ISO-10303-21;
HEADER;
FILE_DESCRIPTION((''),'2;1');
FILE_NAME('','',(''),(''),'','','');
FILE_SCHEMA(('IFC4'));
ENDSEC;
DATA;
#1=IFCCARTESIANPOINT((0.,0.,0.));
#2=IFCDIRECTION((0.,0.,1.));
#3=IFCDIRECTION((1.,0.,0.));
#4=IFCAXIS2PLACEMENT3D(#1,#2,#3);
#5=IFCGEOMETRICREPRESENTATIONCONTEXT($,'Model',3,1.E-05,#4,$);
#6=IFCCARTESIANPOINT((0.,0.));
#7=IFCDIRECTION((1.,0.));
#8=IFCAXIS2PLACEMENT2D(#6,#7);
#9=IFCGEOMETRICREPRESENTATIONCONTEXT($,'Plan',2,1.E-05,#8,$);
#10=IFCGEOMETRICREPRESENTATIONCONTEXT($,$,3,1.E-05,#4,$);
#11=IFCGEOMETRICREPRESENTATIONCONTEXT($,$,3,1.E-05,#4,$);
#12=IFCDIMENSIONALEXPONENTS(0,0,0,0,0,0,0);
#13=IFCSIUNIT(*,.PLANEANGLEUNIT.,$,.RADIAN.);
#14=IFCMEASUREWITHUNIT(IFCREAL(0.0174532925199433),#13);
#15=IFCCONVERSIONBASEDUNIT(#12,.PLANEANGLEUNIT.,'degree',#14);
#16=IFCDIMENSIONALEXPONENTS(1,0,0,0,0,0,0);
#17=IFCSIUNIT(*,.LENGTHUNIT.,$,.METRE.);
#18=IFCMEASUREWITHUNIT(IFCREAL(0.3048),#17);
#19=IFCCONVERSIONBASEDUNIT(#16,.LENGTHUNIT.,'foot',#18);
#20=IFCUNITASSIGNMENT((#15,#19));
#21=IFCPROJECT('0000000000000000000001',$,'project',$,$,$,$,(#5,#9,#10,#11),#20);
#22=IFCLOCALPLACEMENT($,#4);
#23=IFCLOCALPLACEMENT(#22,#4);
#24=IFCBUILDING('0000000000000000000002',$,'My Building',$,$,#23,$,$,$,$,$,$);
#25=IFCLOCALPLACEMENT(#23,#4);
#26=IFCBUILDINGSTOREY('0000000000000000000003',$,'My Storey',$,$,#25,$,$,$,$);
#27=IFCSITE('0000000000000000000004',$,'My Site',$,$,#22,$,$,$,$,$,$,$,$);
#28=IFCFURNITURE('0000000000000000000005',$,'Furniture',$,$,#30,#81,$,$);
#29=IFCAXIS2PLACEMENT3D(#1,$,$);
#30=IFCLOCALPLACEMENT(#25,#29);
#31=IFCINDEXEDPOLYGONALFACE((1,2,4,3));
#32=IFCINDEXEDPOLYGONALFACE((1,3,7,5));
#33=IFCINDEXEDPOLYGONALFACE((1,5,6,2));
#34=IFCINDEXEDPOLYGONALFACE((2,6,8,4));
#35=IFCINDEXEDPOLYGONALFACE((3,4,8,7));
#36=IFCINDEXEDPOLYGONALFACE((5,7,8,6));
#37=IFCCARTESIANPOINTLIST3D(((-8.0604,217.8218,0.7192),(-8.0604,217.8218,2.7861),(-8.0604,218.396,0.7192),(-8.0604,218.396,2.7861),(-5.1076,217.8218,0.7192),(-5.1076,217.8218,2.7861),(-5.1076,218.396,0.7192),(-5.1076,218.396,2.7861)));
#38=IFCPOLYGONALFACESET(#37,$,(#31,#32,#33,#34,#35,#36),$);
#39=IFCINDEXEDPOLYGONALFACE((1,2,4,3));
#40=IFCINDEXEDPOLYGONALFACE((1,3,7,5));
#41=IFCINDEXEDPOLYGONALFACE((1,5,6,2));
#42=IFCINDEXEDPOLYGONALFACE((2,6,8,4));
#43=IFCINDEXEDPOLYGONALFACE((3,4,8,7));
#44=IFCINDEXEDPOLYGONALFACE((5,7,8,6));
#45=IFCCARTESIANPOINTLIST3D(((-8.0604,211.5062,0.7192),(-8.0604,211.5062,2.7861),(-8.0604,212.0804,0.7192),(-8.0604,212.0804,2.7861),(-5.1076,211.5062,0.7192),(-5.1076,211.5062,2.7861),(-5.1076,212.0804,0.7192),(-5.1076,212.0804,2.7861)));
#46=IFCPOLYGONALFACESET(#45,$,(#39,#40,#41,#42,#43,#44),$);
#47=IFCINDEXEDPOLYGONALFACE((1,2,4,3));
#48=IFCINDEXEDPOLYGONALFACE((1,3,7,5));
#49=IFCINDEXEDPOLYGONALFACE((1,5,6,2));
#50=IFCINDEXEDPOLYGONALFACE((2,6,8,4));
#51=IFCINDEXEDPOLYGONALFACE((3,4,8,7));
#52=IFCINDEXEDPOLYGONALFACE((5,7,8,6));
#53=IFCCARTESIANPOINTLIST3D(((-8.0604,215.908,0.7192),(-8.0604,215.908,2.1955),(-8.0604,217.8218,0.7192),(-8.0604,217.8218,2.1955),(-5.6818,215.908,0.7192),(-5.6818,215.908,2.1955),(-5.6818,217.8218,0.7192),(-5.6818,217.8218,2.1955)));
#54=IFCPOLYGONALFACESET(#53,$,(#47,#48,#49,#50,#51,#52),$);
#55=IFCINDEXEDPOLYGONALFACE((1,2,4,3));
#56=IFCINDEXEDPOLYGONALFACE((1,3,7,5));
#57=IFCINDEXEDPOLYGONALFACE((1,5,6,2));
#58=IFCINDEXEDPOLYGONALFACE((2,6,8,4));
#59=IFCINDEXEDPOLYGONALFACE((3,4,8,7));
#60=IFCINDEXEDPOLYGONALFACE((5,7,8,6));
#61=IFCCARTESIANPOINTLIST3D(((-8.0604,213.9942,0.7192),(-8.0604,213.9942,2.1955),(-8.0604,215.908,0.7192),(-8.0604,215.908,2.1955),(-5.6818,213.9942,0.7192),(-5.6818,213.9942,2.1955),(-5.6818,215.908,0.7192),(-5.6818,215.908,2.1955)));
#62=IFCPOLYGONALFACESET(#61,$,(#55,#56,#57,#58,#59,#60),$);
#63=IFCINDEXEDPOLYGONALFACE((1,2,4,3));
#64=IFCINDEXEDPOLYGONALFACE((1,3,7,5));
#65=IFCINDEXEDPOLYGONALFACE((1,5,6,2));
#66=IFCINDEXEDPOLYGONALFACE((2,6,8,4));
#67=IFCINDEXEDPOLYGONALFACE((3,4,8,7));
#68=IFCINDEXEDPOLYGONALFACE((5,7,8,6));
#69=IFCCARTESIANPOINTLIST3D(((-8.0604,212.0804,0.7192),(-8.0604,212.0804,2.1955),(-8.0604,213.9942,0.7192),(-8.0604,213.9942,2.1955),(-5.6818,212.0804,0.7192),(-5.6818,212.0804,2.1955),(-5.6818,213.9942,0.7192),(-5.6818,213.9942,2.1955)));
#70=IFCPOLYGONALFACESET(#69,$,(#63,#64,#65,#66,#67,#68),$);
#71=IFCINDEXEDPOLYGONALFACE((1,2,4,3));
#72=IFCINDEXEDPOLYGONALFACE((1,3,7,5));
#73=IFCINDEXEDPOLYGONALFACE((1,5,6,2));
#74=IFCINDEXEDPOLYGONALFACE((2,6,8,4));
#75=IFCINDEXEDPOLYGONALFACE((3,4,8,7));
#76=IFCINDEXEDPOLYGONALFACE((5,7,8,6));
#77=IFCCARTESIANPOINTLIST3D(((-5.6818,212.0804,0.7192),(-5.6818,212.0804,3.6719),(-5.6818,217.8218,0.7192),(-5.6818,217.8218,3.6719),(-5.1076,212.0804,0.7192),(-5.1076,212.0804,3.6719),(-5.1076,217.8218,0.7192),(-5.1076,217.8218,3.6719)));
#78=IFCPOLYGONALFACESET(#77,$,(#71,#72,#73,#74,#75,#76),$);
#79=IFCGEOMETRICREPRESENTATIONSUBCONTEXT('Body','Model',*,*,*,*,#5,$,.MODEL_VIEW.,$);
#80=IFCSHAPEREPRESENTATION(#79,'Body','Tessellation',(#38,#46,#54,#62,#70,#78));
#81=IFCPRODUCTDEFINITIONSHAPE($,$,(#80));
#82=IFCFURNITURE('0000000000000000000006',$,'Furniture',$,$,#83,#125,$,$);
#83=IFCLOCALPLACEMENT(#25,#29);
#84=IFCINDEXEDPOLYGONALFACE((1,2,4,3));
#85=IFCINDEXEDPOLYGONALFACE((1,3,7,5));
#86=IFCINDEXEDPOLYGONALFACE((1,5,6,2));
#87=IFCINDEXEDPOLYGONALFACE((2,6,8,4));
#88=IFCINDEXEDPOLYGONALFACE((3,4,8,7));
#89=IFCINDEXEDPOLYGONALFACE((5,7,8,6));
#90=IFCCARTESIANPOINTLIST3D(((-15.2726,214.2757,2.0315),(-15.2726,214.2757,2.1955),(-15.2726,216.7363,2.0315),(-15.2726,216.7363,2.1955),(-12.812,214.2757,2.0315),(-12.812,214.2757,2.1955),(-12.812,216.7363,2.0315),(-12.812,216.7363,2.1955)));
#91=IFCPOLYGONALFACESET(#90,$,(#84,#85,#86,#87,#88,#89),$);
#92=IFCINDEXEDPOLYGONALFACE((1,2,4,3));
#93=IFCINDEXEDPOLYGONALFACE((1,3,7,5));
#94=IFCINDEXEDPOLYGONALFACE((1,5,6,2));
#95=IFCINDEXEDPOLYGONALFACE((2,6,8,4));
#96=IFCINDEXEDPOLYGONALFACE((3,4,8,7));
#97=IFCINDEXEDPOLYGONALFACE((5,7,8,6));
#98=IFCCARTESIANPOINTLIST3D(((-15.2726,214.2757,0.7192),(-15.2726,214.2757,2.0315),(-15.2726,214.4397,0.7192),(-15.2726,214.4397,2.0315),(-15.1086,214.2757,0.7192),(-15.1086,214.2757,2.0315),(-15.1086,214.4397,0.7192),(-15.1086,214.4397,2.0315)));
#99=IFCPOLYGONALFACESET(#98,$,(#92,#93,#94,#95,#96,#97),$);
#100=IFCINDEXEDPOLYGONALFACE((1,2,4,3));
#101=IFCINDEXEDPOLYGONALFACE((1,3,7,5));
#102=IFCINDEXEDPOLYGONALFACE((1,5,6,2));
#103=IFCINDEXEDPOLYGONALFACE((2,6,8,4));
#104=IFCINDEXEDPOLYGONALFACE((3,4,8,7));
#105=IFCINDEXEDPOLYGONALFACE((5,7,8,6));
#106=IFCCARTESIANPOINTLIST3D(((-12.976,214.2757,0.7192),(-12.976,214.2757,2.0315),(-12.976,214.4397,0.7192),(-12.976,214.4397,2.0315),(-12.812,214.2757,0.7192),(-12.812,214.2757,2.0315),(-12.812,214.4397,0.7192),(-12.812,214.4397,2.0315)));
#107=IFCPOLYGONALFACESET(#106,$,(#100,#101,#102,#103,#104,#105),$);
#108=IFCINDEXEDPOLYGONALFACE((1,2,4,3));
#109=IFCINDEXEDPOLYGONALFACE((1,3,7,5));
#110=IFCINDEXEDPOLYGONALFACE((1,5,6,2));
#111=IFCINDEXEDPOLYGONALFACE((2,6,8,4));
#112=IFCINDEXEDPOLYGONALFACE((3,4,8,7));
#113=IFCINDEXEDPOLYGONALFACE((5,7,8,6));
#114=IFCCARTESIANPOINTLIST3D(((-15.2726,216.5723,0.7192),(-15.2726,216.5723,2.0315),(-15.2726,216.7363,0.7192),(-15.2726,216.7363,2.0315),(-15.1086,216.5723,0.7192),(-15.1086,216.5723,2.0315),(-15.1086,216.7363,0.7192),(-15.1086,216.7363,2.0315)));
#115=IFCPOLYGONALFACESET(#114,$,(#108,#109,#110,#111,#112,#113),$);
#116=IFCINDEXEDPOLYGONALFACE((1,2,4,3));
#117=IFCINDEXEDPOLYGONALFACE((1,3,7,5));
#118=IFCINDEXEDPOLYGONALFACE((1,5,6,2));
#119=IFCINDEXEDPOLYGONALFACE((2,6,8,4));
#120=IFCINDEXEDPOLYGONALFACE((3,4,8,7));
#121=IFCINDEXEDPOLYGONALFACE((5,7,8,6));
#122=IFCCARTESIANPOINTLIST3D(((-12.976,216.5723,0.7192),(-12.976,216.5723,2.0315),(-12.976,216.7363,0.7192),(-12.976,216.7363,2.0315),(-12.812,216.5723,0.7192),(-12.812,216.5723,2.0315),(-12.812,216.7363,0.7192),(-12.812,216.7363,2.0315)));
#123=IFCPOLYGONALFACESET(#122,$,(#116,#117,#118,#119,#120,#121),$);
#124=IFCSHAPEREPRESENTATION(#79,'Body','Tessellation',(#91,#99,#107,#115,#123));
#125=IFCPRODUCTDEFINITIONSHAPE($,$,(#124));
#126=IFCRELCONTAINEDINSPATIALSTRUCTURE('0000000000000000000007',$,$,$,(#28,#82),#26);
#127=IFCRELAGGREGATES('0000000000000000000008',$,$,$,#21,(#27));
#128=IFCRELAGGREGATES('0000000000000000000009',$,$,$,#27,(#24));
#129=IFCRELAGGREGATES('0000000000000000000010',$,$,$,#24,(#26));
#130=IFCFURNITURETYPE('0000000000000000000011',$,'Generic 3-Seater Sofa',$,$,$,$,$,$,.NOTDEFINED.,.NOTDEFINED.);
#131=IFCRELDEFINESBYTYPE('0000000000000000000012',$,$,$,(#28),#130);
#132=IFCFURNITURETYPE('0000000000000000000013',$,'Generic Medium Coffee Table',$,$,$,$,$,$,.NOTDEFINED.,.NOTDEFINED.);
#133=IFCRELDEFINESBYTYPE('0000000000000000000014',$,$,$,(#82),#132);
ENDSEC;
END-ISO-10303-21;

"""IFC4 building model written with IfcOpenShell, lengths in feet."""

from ifc_helpers import new_model, entity, si_unit, converted_unit, frame, origin_with_axes, origin_2d_with_axis, place, context, subcontext, project, spatial, line, indexed_curve, outline, extrude, shape, source, transform, mapped, type_object, type_shapes, element, save


model = new_model("IFC4")

# Units and contexts
model_context = context("Model", 3, precision=1e-05, world=origin_with_axes())
plan_context = context("Plan", 2, precision=1e-05, world=origin_2d_with_axis())
context_of_model_1 = context(None, 3, precision=1e-05, world=origin_with_axes())
context_of_model_2 = context(None, 3, precision=1e-05, world=origin_with_axes())
body_context_1 = subcontext(model_context, "Body", "Model", "MODEL_VIEW")
body_context_2 = subcontext(plan_context, "Body", "Plan", "PLAN_VIEW")
ifc_project = project(units=[converted_unit("PLANEANGLEUNIT", "degree", entity("IfcReal", 0.0174532925199433), si_unit("PLANEANGLEUNIT", "RADIAN"), dimensions=[0, 0, 0, 0, 0, 0, 0]), converted_unit("LENGTHUNIT", "foot", entity("IfcReal", 0.3048), si_unit("LENGTHUNIT", "METRE"), dimensions=[1, 0, 0, 0, 0, 0, 0])], contexts=[model_context, plan_context, context_of_model_1, context_of_model_2])

# Site, building, storey
site_placement = place(None, origin_with_axes())
site = spatial("IfcSite", under=ifc_project, at=site_placement, Name="My Site")
building_placement = place(site_placement, origin_with_axes())
building = spatial("IfcBuilding", under=site, at=building_placement, Name="My Building")
storey_placement = place(building_placement, origin_with_axes())
storey = spatial("IfcBuildingStorey", under=building, at=storey_placement, Name="My Storey")

# Furniture
furniture_type_1 = type_object("IfcFurnitureType", Name="Generic 3-Seater Sofa", AssemblyPlace="NOTDEFINED", PredefinedType="NOTDEFINED")
shared_shape_1 = source(origin_with_axes(), body_context_1, "Body", "SweptSolid", [
    extrude(outline(indexed_curve([(0.0, 0.0), (0.5741, 0.0), (0.5741, 2.9528), (0.0, 2.9528)], segments=[line(1, 2), line(2, 3), line(3, 4), line(4, 1)])), frame((-3.4449, -2.9528, 0.0), z_axis=(0.0, 0.0, 1.0), x_axis=(1.0, 0.0, 0.0)), (0.0, 0.0, 1.0), 2.0669),
    extrude(outline(indexed_curve([(0.0, 0.0), (0.5741, 0.0), (0.5741, 2.9528), (0.0, 2.9528)], segments=[line(1, 2), line(2, 3), line(3, 4), line(4, 1)])), frame((2.8707, -2.9528, 0.0), z_axis=(0.0, 0.0, 1.0), x_axis=(1.0, 0.0, 0.0)), (0.0, 0.0, 1.0), 2.0669),
    extrude(outline(indexed_curve([(0.5741, 0.0), (2.488, 0.0), (2.488, 2.3786), (0.5741, 2.3786)], segments=[line(1, 2), line(2, 3), line(3, 4), line(4, 1)])), frame((-3.4449, -2.9528, 0.0), z_axis=(0.0, 0.0, 1.0), x_axis=(1.0, 0.0, 0.0)), (0.0, 0.0, 1.0), 1.4764),
    extrude(outline(indexed_curve([(2.488, 0.0), (4.4018, 0.0), (4.4018, 2.3786), (2.488, 2.3786)], segments=[line(1, 2), line(2, 3), line(3, 4), line(4, 1)])), frame((-3.4449, -2.9528, 0.0), z_axis=(0.0, 0.0, 1.0), x_axis=(1.0, 0.0, 0.0)), (0.0, 0.0, 1.0), 1.4764),
    extrude(outline(indexed_curve([(4.4018, 0.0), (6.3156, 0.0), (6.3156, 2.3786), (4.4018, 2.3786)], segments=[line(1, 2), line(2, 3), line(3, 4), line(4, 1)])), frame((-3.4449, -2.9528, 0.0), z_axis=(0.0, 0.0, 1.0), x_axis=(1.0, 0.0, 0.0)), (0.0, 0.0, 1.0), 1.4764),
    extrude(outline(indexed_curve([(0.5741, 2.3786), (6.3156, 2.3786), (6.3156, 2.9528), (0.5741, 2.9528)], segments=[line(1, 2), line(2, 3), line(3, 4), line(4, 1)])), frame((-3.4449, -2.9528, 0.0), z_axis=(0.0, 0.0, 1.0), x_axis=(1.0, 0.0, 0.0)), (0.0, 0.0, 1.0), 2.9528),
])
shared_shape_2 = source(origin_with_axes(), body_context_2, "Body", "Annotation2D", [
    entity("IfcAnnotationFillArea", entity("IfcIndexedPolyCurve", entity("IfcCartesianPointList2D", [[-3.4449, -2.9528], [-2.8707, -2.9528], [-2.8707, 0.0], [-3.4449, 0.0], [2.8707, -2.9528], [3.4449, -2.9528], [3.4449, 0.0], [2.8707, 0.0], [-2.8707, -2.9528], [-0.9569, -2.9528], [-0.9569, -2.9528], [-0.9569, -0.5741], [-2.8707, -0.5741], [-0.9569, -2.9528], [0.9569, -2.9528], [0.9569, -2.9528], [0.9569, -0.5741], [-0.9569, -0.5741], [-0.9569, -0.5741], [0.9569, -2.9528], [2.8707, -2.9528], [2.8707, -0.5741], [0.9569, -0.5741], [-2.8707, -0.5741], [2.8707, -0.5741], [2.8707, 0.0], [-2.8707, 0.0], [0.9569, -0.5741]]), [entity("IfcLineIndex", [5, 8]), entity("IfcLineIndex", [8, 7]), entity("IfcLineIndex", [7, 6]), entity("IfcLineIndex", [6, 5])])),
    entity("IfcAnnotationFillArea", entity("IfcIndexedPolyCurve", entity("IfcCartesianPointList2D", [[-3.4449, -2.9528], [-2.8707, -2.9528], [-2.8707, 0.0], [-3.4449, 0.0], [2.8707, -2.9528], [3.4449, -2.9528], [3.4449, 0.0], [2.8707, 0.0], [-2.8707, -2.9528], [-0.9569, -2.9528], [-0.9569, -2.9528], [-0.9569, -0.5741], [-2.8707, -0.5741], [-0.9569, -2.9528], [0.9569, -2.9528], [0.9569, -2.9528], [0.9569, -0.5741], [-0.9569, -0.5741], [-0.9569, -0.5741], [0.9569, -2.9528], [2.8707, -2.9528], [2.8707, -0.5741], [0.9569, -0.5741], [-2.8707, -0.5741], [2.8707, -0.5741], [2.8707, 0.0], [-2.8707, 0.0], [0.9569, -0.5741]]), [entity("IfcLineIndex", [20, 23]), entity("IfcLineIndex", [23, 22]), entity("IfcLineIndex", [22, 21]), entity("IfcLineIndex", [21, 20])])),
    entity("IfcAnnotationFillArea", entity("IfcIndexedPolyCurve", entity("IfcCartesianPointList2D", [[-3.4449, -2.9528], [-2.8707, -2.9528], [-2.8707, 0.0], [-3.4449, 0.0], [2.8707, -2.9528], [3.4449, -2.9528], [3.4449, 0.0], [2.8707, 0.0], [-2.8707, -2.9528], [-0.9569, -2.9528], [-0.9569, -2.9528], [-0.9569, -0.5741], [-2.8707, -0.5741], [-0.9569, -2.9528], [0.9569, -2.9528], [0.9569, -2.9528], [0.9569, -0.5741], [-0.9569, -0.5741], [-0.9569, -0.5741], [0.9569, -2.9528], [2.8707, -2.9528], [2.8707, -0.5741], [0.9569, -0.5741], [-2.8707, -0.5741], [2.8707, -0.5741], [2.8707, 0.0], [-2.8707, 0.0], [0.9569, -0.5741]]), [entity("IfcLineIndex", [1, 4]), entity("IfcLineIndex", [4, 3]), entity("IfcLineIndex", [3, 2]), entity("IfcLineIndex", [2, 1])])),
    entity("IfcAnnotationFillArea", entity("IfcIndexedPolyCurve", entity("IfcCartesianPointList2D", [[-3.4449, -2.9528], [-2.8707, -2.9528], [-2.8707, 0.0], [-3.4449, 0.0], [2.8707, -2.9528], [3.4449, -2.9528], [3.4449, 0.0], [2.8707, 0.0], [-2.8707, -2.9528], [-0.9569, -2.9528], [-0.9569, -2.9528], [-0.9569, -0.5741], [-2.8707, -0.5741], [-0.9569, -2.9528], [0.9569, -2.9528], [0.9569, -2.9528], [0.9569, -0.5741], [-0.9569, -0.5741], [-0.9569, -0.5741], [0.9569, -2.9528], [2.8707, -2.9528], [2.8707, -0.5741], [0.9569, -0.5741], [-2.8707, -0.5741], [2.8707, -0.5741], [2.8707, 0.0], [-2.8707, 0.0], [0.9569, -0.5741]]), [entity("IfcLineIndex", [9, 13]), entity("IfcLineIndex", [13, 12]), entity("IfcLineIndex", [12, 11]), entity("IfcLineIndex", [11, 10]), entity("IfcLineIndex", [10, 9])])),
    entity("IfcAnnotationFillArea", entity("IfcIndexedPolyCurve", entity("IfcCartesianPointList2D", [[-3.4449, -2.9528], [-2.8707, -2.9528], [-2.8707, 0.0], [-3.4449, 0.0], [2.8707, -2.9528], [3.4449, -2.9528], [3.4449, 0.0], [2.8707, 0.0], [-2.8707, -2.9528], [-0.9569, -2.9528], [-0.9569, -2.9528], [-0.9569, -0.5741], [-2.8707, -0.5741], [-0.9569, -2.9528], [0.9569, -2.9528], [0.9569, -2.9528], [0.9569, -0.5741], [-0.9569, -0.5741], [-0.9569, -0.5741], [0.9569, -2.9528], [2.8707, -2.9528], [2.8707, -0.5741], [0.9569, -0.5741], [-2.8707, -0.5741], [2.8707, -0.5741], [2.8707, 0.0], [-2.8707, 0.0], [0.9569, -0.5741]]), [entity("IfcLineIndex", [14, 19]), entity("IfcLineIndex", [19, 28]), entity("IfcLineIndex", [28, 15]), entity("IfcLineIndex", [15, 14])])),
    entity("IfcAnnotationFillArea", entity("IfcIndexedPolyCurve", entity("IfcCartesianPointList2D", [[-3.4449, -2.9528], [-2.8707, -2.9528], [-2.8707, 0.0], [-3.4449, 0.0], [2.8707, -2.9528], [3.4449, -2.9528], [3.4449, 0.0], [2.8707, 0.0], [-2.8707, -2.9528], [-0.9569, -2.9528], [-0.9569, -2.9528], [-0.9569, -0.5741], [-2.8707, -0.5741], [-0.9569, -2.9528], [0.9569, -2.9528], [0.9569, -2.9528], [0.9569, -0.5741], [-0.9569, -0.5741], [-0.9569, -0.5741], [0.9569, -2.9528], [2.8707, -2.9528], [2.8707, -0.5741], [0.9569, -0.5741], [-2.8707, -0.5741], [2.8707, -0.5741], [2.8707, 0.0], [-2.8707, 0.0], [0.9569, -0.5741]]), [entity("IfcLineIndex", [24, 27]), entity("IfcLineIndex", [27, 26]), entity("IfcLineIndex", [26, 25]), entity("IfcLineIndex", [25, 24])])),
])
type_shapes(furniture_type_1, [shared_shape_1, shared_shape_2])
for number, where, z_axis, x_axis, name in (
    (1, (-5.1076, 214.9511, 0.7192), (0.0, 0.0, 1.0), (0.0, -1.0, 0.0), "Furniture"),
):
    element("IfcFurniture", number, at=place(storey_placement, frame(where, z_axis=z_axis, x_axis=x_axis)), inside=storey, type_object=furniture_type_1, Name=name, shapes=[
        shape(body_context_1, "Body", "MappedRepresentation", [mapped(shared_shape_1, transform((0.0, 0.0, 0.0), x_axis=(1.0, 0.0, 0.0), y_axis=(0.0, 1.0, 0.0), z_axis=(0.0, 0.0, 1.0), scale=1.0))]),
        shape(body_context_2, "Body", "MappedRepresentation", [mapped(shared_shape_2, transform((0.0, 0.0, 0.0), x_axis=(1.0, 0.0, 0.0), y_axis=(0.0, 1.0, 0.0), z_axis=(0.0, 0.0, 1.0), scale=1.0))]),
    ])
furniture_type_2 = type_object("IfcFurnitureType", Name="Generic Medium Coffee Table", AssemblyPlace="NOTDEFINED", PredefinedType="NOTDEFINED")
shared_shape_3 = source(origin_with_axes(), body_context_1, "Body", "SweptSolid", [
    extrude(outline(indexed_curve([(0.0, 0.0), (2.4606, 0.0), (2.4606, 2.4606), (0.0, 2.4606)], segments=[line(1, 2), line(2, 3), line(3, 4), line(4, 1)])), frame((-1.2303, -1.2303, 1.3123), z_axis=(0.0, 0.0, 1.0), x_axis=(1.0, 0.0, 0.0)), (0.0, 0.0, 1.0), 0.164),
    extrude(outline(indexed_curve([(0.0, 0.0), (0.164, 0.0), (0.164, 0.164), (0.0, 0.164)], segments=[line(1, 2), line(2, 3), line(3, 4), line(4, 1)])), frame((-1.2303, -1.2303, 0.0), z_axis=(0.0, 0.0, 1.0), x_axis=(1.0, 0.0, 0.0)), (0.0, 0.0, 1.0), 1.3123),
    extrude(outline(indexed_curve([(2.4606, 0.0), (2.2966, 0.0), (2.2966, 0.164), (2.4606, 0.164)], segments=[line(1, 2), line(2, 3), line(3, 4), line(4, 1)])), frame((-1.2303, -1.2303, 0.0), z_axis=(0.0, 0.0, 1.0), x_axis=(1.0, 0.0, 0.0)), (0.0, 0.0, 1.0), 1.3123),
    extrude(outline(indexed_curve([(0.0, 2.4606), (0.164, 2.4606), (0.164, 2.2966), (0.0, 2.2966)], segments=[line(1, 2), line(2, 3), line(3, 4), line(4, 1)])), frame((-1.2303, -1.2303, 0.0), z_axis=(0.0, 0.0, 1.0), x_axis=(1.0, 0.0, 0.0)), (0.0, 0.0, 1.0), 1.3123),
    extrude(outline(indexed_curve([(2.4606, 2.4606), (2.2966, 2.4606), (2.2966, 2.2966), (2.4606, 2.2966)], segments=[line(1, 2), line(2, 3), line(3, 4), line(4, 1)])), frame((-1.2303, -1.2303, 0.0), z_axis=(0.0, 0.0, 1.0), x_axis=(1.0, 0.0, 0.0)), (0.0, 0.0, 1.0), 1.3123),
])
shared_shape_4 = source(origin_with_axes(), body_context_2, "Body", "Annotation2D", [
    entity("IfcAnnotationFillArea", entity("IfcIndexedPolyCurve", entity("IfcCartesianPointList2D", [[-1.2303, -1.2303], [1.2303, -1.2303], [1.2303, 1.2303], [-1.2303, 1.2303]]), [entity("IfcLineIndex", [1, 4]), entity("IfcLineIndex", [4, 3]), entity("IfcLineIndex", [3, 2]), entity("IfcLineIndex", [2, 1])])),
])
type_shapes(furniture_type_2, [shared_shape_3, shared_shape_4])
for number, where, z_axis, x_axis, name in (
    (2, (-14.0423, 215.506, 0.7192), (0.0, 0.0, 1.0), (1.0, 0.0, 0.0), "Furniture"),
):
    element("IfcFurniture", number, at=place(storey_placement, frame(where, z_axis=z_axis, x_axis=x_axis)), inside=storey, type_object=furniture_type_2, Name=name, shapes=[
        shape(body_context_1, "Body", "MappedRepresentation", [mapped(shared_shape_3, transform((0.0, 0.0, 0.0), x_axis=(1.0, 0.0, 0.0), y_axis=(0.0, 1.0, 0.0), z_axis=(0.0, 0.0, 1.0), scale=1.0))]),
        shape(body_context_2, "Body", "MappedRepresentation", [mapped(shared_shape_4, transform((0.0, 0.0, 0.0), x_axis=(1.0, 0.0, 0.0), y_axis=(0.0, 1.0, 0.0), z_axis=(0.0, 0.0, 1.0), scale=1.0))]),
    ])

save(model, "model.ifc")
